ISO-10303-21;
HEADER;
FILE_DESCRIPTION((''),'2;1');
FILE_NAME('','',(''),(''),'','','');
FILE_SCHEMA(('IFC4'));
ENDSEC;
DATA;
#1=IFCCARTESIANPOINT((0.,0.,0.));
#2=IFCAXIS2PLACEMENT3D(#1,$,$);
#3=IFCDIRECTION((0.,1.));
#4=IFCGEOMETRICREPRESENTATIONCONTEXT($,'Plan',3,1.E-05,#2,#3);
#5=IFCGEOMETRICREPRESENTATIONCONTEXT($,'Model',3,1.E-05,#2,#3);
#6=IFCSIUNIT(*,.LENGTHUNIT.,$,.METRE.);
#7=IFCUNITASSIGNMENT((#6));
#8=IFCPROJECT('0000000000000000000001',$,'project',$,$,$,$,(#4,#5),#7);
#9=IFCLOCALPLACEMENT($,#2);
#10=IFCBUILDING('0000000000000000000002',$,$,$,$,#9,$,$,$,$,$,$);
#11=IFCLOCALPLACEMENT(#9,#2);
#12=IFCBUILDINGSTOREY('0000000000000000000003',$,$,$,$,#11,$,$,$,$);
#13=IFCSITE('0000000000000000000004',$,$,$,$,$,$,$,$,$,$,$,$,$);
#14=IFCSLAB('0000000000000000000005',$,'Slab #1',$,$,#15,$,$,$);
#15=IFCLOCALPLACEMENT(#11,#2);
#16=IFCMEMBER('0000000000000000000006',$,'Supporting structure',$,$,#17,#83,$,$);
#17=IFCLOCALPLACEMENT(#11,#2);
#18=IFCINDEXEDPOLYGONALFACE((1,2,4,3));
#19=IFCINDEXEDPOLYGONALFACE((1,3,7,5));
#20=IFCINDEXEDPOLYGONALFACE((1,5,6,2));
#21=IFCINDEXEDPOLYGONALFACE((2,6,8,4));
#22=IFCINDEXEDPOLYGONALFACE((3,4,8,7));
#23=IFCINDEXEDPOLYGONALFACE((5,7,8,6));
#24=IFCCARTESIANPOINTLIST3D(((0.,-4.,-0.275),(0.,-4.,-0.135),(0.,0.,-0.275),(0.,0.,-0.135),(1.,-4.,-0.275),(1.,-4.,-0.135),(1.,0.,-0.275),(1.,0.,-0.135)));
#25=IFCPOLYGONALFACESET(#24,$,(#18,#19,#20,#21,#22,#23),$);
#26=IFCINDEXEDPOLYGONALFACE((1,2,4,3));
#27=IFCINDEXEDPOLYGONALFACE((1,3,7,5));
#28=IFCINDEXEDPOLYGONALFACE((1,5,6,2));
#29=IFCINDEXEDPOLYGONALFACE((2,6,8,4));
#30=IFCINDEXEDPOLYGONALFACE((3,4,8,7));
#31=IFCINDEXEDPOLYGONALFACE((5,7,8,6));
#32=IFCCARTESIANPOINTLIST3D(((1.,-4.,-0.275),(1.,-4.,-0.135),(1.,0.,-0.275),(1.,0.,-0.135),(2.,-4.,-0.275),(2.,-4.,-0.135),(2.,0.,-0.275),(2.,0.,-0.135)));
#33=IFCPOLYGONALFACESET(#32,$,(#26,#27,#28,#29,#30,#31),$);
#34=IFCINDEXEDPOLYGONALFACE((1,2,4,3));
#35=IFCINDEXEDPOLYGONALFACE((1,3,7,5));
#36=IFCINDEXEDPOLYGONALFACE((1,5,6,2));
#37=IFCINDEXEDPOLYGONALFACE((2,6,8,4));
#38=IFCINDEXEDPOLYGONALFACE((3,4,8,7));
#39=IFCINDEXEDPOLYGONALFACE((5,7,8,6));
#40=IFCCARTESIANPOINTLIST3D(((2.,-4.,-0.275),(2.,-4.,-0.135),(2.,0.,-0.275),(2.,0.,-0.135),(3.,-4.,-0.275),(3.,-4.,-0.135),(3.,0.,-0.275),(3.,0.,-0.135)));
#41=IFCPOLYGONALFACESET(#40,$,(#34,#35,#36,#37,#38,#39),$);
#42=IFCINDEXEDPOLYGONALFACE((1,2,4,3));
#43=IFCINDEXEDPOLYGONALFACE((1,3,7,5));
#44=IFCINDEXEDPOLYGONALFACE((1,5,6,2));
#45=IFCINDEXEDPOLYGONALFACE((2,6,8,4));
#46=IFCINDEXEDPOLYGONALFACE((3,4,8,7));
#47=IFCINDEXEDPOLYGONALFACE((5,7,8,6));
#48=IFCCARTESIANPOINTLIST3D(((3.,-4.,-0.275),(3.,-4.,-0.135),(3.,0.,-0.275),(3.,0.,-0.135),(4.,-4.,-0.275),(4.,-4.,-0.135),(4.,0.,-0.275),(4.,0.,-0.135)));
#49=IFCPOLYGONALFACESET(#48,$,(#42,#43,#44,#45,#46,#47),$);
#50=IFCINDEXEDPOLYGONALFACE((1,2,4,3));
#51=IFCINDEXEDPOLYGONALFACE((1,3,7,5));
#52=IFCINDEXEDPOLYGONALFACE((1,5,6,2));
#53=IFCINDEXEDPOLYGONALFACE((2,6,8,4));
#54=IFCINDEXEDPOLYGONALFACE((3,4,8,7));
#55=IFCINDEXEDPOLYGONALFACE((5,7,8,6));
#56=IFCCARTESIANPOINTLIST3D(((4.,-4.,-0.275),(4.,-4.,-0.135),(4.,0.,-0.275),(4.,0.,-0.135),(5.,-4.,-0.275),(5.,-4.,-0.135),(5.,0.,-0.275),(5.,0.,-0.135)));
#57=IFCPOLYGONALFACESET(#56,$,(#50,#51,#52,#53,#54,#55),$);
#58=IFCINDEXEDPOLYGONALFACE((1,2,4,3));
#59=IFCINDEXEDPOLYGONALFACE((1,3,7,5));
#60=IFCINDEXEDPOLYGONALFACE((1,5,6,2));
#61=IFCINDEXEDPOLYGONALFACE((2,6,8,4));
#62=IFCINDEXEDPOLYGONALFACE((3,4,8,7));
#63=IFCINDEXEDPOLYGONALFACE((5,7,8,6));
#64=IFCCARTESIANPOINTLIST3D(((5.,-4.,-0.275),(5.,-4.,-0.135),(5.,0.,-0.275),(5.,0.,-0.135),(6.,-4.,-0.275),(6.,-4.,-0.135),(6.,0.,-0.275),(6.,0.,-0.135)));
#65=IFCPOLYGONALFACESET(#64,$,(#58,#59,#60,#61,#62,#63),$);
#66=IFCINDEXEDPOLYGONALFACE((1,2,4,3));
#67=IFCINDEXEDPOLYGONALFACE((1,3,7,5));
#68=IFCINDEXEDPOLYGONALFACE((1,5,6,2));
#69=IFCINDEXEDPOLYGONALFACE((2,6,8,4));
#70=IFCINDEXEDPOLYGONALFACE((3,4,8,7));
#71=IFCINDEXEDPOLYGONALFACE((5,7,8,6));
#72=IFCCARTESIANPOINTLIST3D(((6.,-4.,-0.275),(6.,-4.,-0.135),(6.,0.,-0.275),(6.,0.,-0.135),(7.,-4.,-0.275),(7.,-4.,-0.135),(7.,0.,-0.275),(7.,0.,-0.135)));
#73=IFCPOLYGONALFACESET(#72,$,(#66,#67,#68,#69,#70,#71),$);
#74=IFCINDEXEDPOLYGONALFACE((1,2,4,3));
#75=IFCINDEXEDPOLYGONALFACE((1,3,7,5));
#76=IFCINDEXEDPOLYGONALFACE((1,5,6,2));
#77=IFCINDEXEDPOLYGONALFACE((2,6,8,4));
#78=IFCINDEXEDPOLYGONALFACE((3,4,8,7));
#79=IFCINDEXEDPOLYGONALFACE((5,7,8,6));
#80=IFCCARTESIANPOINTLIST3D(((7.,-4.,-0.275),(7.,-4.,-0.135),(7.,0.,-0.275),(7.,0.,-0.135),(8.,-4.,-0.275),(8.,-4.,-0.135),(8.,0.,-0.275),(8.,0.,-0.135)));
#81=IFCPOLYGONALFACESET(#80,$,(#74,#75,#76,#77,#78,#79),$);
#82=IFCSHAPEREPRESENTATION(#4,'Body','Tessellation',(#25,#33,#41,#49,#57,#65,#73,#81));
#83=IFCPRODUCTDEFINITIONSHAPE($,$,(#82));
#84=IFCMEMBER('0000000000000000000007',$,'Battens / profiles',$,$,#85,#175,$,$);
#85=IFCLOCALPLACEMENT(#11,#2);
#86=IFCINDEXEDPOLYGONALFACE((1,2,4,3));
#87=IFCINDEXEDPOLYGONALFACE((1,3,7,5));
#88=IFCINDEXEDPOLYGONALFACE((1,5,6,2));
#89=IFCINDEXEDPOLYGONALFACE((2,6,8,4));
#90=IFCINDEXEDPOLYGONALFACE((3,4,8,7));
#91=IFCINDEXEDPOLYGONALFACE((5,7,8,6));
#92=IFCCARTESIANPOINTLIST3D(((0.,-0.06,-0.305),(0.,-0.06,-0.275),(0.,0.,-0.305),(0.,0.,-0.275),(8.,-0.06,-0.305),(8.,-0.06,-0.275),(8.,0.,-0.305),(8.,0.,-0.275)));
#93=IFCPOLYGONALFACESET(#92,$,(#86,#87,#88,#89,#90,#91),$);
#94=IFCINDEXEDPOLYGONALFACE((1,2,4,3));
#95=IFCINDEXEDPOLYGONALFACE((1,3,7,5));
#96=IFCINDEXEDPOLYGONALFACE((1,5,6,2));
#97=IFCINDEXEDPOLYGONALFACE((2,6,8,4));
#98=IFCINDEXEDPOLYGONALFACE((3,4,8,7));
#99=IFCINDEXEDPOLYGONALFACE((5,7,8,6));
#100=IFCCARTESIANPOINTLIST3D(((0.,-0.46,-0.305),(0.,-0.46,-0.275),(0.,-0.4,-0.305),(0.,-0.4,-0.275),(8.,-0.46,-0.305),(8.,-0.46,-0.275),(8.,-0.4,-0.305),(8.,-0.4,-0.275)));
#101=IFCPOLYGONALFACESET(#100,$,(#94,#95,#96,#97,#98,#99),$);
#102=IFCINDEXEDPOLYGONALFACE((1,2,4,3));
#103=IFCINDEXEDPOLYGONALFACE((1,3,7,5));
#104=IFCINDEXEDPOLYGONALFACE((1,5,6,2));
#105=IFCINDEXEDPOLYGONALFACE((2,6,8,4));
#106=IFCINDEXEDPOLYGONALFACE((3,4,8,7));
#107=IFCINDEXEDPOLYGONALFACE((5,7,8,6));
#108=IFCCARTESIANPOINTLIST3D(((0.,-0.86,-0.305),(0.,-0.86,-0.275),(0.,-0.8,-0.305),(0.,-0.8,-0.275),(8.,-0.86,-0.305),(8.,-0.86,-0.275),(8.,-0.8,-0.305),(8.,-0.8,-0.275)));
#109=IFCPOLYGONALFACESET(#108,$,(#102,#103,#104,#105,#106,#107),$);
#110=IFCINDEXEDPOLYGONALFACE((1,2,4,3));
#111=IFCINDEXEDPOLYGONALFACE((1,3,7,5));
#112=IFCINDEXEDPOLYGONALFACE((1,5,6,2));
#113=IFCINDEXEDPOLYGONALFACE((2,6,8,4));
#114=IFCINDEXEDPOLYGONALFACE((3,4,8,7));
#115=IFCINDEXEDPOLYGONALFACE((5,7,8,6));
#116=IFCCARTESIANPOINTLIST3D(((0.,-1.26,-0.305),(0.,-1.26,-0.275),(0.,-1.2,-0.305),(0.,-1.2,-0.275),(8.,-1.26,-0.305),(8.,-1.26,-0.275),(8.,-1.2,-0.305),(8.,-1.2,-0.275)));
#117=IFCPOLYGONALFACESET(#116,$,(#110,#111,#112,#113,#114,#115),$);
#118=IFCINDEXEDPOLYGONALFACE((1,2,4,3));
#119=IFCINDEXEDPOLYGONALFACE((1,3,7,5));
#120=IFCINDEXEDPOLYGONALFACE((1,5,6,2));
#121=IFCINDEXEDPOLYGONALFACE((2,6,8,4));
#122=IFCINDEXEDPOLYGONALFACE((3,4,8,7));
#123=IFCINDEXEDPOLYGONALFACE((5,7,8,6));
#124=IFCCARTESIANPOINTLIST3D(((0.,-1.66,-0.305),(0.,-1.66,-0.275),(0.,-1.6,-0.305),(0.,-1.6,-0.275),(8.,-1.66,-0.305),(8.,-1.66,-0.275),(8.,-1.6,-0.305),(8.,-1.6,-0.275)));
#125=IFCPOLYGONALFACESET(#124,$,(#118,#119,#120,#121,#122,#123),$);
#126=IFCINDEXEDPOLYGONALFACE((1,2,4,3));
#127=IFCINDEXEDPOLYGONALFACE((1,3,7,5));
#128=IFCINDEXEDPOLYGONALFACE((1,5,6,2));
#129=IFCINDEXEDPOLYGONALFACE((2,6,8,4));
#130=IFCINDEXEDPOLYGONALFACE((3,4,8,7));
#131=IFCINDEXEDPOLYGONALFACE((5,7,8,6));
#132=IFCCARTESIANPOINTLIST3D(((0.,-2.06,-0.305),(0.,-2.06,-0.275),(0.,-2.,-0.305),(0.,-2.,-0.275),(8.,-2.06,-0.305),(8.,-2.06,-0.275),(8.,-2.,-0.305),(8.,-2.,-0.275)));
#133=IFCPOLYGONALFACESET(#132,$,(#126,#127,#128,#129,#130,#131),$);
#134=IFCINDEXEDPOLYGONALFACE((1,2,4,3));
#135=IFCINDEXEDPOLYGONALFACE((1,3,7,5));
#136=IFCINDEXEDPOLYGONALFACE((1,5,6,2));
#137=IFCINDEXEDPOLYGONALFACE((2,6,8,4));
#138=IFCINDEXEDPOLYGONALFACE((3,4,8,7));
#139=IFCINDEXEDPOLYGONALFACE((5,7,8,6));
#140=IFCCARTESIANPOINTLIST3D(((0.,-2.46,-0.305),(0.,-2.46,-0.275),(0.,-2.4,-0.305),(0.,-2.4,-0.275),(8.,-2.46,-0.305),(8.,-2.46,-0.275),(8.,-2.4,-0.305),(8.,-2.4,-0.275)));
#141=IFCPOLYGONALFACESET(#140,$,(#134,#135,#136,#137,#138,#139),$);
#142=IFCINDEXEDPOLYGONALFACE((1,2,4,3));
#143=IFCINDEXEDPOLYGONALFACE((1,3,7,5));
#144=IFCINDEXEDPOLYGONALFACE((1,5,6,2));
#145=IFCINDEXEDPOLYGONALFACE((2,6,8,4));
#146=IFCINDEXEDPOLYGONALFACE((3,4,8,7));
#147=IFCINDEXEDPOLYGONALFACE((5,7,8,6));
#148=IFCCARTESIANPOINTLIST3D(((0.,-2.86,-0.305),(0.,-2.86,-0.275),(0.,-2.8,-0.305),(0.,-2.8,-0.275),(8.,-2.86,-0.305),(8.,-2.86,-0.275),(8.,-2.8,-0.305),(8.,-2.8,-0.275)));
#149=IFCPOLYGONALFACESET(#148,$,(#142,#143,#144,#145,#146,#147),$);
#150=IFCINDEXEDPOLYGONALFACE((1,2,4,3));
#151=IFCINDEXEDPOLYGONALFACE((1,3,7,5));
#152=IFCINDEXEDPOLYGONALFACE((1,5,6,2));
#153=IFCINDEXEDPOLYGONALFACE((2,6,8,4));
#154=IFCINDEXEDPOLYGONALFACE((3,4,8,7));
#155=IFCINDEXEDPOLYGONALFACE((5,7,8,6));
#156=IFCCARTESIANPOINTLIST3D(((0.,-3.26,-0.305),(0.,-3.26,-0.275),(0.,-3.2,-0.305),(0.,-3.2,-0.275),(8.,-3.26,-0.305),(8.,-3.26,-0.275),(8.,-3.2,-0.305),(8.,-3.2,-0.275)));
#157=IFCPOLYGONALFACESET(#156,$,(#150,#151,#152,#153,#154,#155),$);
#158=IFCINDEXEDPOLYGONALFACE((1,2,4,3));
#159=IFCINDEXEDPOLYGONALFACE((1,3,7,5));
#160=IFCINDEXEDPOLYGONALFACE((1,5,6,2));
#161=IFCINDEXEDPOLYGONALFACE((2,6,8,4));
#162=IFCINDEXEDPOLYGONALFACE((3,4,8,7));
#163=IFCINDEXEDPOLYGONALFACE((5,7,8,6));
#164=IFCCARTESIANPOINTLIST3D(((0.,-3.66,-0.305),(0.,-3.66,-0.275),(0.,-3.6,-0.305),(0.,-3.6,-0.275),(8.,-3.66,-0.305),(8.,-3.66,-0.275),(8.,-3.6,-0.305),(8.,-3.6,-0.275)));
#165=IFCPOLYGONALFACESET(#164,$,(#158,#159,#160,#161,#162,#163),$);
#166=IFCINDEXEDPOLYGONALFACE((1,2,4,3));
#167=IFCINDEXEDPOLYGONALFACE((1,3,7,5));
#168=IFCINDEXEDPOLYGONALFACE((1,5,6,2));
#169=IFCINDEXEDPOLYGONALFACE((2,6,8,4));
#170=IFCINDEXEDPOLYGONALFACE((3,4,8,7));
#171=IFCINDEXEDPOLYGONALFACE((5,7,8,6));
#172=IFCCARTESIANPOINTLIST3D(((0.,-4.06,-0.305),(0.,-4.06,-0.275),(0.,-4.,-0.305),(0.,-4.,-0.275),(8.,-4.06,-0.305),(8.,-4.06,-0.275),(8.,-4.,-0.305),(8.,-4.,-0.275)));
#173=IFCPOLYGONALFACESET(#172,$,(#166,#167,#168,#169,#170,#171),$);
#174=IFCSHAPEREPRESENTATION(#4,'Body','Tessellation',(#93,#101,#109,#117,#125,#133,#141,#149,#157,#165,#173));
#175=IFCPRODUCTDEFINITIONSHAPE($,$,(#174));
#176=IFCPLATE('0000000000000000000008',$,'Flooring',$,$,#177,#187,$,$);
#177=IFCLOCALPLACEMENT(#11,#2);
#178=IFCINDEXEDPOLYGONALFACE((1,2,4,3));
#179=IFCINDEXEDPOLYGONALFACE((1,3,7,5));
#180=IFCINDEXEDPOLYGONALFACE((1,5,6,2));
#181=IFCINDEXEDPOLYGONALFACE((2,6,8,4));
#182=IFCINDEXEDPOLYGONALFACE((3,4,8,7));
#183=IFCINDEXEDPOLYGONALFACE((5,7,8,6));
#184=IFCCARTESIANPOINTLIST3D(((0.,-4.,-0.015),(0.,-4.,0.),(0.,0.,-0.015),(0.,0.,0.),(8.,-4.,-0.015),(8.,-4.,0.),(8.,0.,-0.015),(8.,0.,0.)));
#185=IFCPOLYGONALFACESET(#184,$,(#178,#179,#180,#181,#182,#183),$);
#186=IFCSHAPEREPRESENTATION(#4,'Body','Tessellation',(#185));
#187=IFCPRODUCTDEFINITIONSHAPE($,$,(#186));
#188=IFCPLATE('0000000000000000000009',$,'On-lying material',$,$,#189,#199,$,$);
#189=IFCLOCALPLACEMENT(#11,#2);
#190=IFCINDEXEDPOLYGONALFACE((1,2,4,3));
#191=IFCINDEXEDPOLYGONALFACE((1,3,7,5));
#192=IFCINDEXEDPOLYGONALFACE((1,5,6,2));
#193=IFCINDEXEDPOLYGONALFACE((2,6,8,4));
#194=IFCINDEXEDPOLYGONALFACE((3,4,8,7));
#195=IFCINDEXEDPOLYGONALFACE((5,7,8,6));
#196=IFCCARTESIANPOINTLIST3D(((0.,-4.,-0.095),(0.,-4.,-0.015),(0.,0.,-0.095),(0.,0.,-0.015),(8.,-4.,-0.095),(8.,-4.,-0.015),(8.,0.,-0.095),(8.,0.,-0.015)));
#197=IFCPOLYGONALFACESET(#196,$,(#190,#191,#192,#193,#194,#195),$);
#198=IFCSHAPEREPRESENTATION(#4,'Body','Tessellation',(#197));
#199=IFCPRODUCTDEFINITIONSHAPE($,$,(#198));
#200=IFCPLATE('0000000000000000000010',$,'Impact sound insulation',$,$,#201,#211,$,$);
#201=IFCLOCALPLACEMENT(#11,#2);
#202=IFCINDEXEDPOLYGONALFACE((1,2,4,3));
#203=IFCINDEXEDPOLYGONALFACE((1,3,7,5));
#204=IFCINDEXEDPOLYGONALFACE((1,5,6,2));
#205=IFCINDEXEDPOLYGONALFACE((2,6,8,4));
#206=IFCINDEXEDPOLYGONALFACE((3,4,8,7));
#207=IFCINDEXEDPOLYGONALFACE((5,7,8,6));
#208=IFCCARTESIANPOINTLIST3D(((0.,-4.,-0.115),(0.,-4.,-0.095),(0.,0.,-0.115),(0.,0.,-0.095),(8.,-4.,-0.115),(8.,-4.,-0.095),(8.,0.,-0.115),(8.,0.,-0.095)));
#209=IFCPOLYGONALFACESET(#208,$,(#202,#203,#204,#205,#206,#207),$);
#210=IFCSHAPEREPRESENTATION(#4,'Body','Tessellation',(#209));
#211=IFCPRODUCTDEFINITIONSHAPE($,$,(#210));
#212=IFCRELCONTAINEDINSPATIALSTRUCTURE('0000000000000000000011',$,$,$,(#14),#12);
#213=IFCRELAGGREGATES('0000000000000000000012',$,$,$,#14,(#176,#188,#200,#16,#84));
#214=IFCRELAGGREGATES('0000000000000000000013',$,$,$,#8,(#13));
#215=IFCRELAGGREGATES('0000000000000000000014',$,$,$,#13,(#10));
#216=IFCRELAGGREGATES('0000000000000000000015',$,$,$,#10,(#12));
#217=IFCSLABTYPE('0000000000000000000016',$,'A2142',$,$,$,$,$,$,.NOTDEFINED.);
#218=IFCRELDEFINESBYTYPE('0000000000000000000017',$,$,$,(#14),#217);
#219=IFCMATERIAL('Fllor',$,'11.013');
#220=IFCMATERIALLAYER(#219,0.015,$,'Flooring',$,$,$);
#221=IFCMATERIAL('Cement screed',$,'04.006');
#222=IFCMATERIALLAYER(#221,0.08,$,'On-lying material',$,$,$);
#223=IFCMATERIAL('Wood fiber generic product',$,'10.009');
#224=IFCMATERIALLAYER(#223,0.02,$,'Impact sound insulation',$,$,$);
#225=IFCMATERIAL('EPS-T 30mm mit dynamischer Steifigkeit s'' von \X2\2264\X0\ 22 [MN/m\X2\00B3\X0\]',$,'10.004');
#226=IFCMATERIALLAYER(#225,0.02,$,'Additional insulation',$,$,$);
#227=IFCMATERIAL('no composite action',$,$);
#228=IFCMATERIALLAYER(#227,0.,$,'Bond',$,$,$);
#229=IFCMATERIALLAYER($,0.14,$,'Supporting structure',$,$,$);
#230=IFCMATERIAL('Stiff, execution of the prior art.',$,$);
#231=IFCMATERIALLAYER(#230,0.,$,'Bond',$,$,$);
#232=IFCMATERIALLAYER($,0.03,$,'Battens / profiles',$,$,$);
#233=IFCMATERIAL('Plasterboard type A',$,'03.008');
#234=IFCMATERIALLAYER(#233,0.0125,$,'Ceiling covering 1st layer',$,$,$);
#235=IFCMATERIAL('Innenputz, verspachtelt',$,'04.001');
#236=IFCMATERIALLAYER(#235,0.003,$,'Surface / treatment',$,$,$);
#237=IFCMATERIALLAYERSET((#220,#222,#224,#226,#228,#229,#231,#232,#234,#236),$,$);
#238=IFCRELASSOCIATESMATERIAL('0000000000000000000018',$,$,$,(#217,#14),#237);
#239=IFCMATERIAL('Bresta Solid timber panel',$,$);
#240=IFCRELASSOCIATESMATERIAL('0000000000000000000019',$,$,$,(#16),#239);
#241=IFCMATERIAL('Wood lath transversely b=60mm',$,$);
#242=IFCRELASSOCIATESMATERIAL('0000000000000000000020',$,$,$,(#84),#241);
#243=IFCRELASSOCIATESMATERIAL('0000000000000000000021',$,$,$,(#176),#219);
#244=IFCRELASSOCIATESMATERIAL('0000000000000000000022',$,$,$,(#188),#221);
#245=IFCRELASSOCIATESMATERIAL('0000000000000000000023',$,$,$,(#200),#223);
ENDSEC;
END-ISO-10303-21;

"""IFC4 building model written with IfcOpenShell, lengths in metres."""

from ifc_helpers import new_model, si_unit, direction, frame, frame_2d, origin, origin_with_axes, place, context, project, spatial, rectangle, extrude, material, layer, layer_set, type_object, element, aggregate, save


model = new_model("IFC4")

# Units and contexts
plan_context = context("Plan", 3, precision=1e-05, world=origin(), true_north=direction((0.0, 1.0)))
model_context = context("Model", 3, precision=1e-05, world=origin(), true_north=direction((0.0, 1.0)))
ifc_project = project(units=[si_unit("LENGTHUNIT", "METRE")], contexts=[plan_context, model_context])

# Site, building, storey
site = spatial("IfcSite", under=ifc_project)
building_placement = place(None, origin())
building = spatial("IfcBuilding", under=site, at=building_placement)
storey_placement = place(building_placement, origin())
storey = spatial("IfcBuildingStorey", under=building, at=storey_placement)

# Slab, members, plates
ifc_material_1 = material(Name="Fllor", Category="11.013")
ifc_layer_1 = layer(ifc_material_1, 0.015, Name="Flooring")
ifc_material_2 = material(Name="Cement screed", Category="04.006")
ifc_layer_2 = layer(ifc_material_2, 0.08, Name="On-lying material")
ifc_material_3 = material(Name="Wood fiber generic product", Category="10.009")
ifc_layer_3 = layer(ifc_material_3, 0.02, Name="Impact sound insulation")
ifc_material_4 = material(Name="EPS-T 30mm mit dynamischer Steifigkeit s' von ≤ 22 [MN/m³]", Category="10.004")
ifc_layer_4 = layer(ifc_material_4, 0.02, Name="Additional insulation")
ifc_material_5 = material(Name="no composite action")
ifc_layer_5 = layer(ifc_material_5, 0.0, Name="Bond")
ifc_layer_6 = layer(None, 0.14, Name="Supporting structure")
ifc_material_6 = material(Name="Stiff, execution of the prior art.")
ifc_layer_7 = layer(ifc_material_6, 0.0, Name="Bond")
ifc_layer_8 = layer(None, 0.03, Name="Battens / profiles")
ifc_material_7 = material(Name="Plasterboard type A", Category="03.008")
ifc_layer_9 = layer(ifc_material_7, 0.0125, Name="Ceiling covering 1st layer")
ifc_material_8 = material(Name="Innenputz, verspachtelt", Category="04.001")
ifc_layer_10 = layer(ifc_material_8, 0.003, Name="Surface / treatment")
ifc_layer_set = layer_set([ifc_layer_1, ifc_layer_2, ifc_layer_3, ifc_layer_4, ifc_layer_5, ifc_layer_6, ifc_layer_7, ifc_layer_8, ifc_layer_9, ifc_layer_10])
slab_type = type_object("IfcSlabType", Name="A2142", PredefinedType="NOTDEFINED", material=ifc_layer_set)
slab_placement = place(None, frame((0.0, 0.0, 0.0), z_axis=(0.0, 0.0, -1.0), x_axis=(1.0, 0.0, 0.0)))
slab = element("IfcSlab", 1, at=slab_placement, inside=storey, type_object=slab_type, material=ifc_layer_set, Name="Slab #1")
ifc_material_9 = material(Name="Bresta Solid timber panel")
member_1_placement = place(slab_placement, origin())
member_1 = element("IfcMember", 2, at=member_1_placement, material=ifc_material_9, Name="Supporting structure", context=plan_context, shape_type="SweptSolid", body=[
    extrude(rectangle(XDim=1.0, YDim=0.14, at=frame_2d((0.5, 0.07), x_axis=(1.0, 0.0))), frame((0.0, 4.0, 0.135), z_axis=(0.0, -1.0, 0.0), x_axis=(1.0, 0.0, 0.0)), (0.0, 0.0, 1.0), 4.0),
    extrude(rectangle(XDim=1.0, YDim=0.14, at=frame_2d((0.5, 0.07), x_axis=(1.0, 0.0))), frame((1.0, 4.0, 0.135), z_axis=(0.0, -1.0, 0.0), x_axis=(1.0, 0.0, 0.0)), (0.0, 0.0, 1.0), 4.0),
    extrude(rectangle(XDim=1.0, YDim=0.14, at=frame_2d((0.5, 0.07), x_axis=(1.0, 0.0))), frame((2.0, 4.0, 0.135), z_axis=(0.0, -1.0, 0.0), x_axis=(1.0, 0.0, 0.0)), (0.0, 0.0, 1.0), 4.0),
    extrude(rectangle(XDim=1.0, YDim=0.14, at=frame_2d((0.5, 0.07), x_axis=(1.0, 0.0))), frame((3.0, 4.0, 0.135), z_axis=(0.0, -1.0, 0.0), x_axis=(1.0, 0.0, 0.0)), (0.0, 0.0, 1.0), 4.0),
    extrude(rectangle(XDim=1.0, YDim=0.14, at=frame_2d((0.5, 0.07), x_axis=(1.0, 0.0))), frame((4.0, 4.0, 0.135), z_axis=(0.0, -1.0, 0.0), x_axis=(1.0, 0.0, 0.0)), (0.0, 0.0, 1.0), 4.0),
    extrude(rectangle(XDim=1.0, YDim=0.14, at=frame_2d((0.5, 0.07), x_axis=(1.0, 0.0))), frame((5.0, 4.0, 0.135), z_axis=(0.0, -1.0, 0.0), x_axis=(1.0, 0.0, 0.0)), (0.0, 0.0, 1.0), 4.0),
    extrude(rectangle(XDim=1.0, YDim=0.14, at=frame_2d((0.5, 0.07), x_axis=(1.0, 0.0))), frame((6.0, 4.0, 0.135), z_axis=(0.0, -1.0, 0.0), x_axis=(1.0, 0.0, 0.0)), (0.0, 0.0, 1.0), 4.0),
    extrude(rectangle(XDim=1.0, YDim=0.14, at=frame_2d((0.5, 0.07), x_axis=(1.0, 0.0))), frame((7.0, 4.0, 0.135), z_axis=(0.0, -1.0, 0.0), x_axis=(1.0, 0.0, 0.0)), (0.0, 0.0, 1.0), 4.0),
])
ifc_material_10 = material(Name="Wood lath transversely b=60mm")
member_2_placement = place(slab_placement, origin())
member_2 = element("IfcMember", 3, at=member_2_placement, material=ifc_material_10, Name="Battens / profiles", context=plan_context, shape_type="SweptSolid", body=[
    extrude(rectangle(XDim=0.06, YDim=0.03, at=frame_2d((0.03, 0.015), x_axis=(1.0, 0.0))), frame((0.0, 0.0, 0.275), z_axis=(1.0, 0.0, 0.0), x_axis=(0.0, 1.0, 0.0)), (0.0, 0.0, 1.0), 8.0),
    extrude(rectangle(XDim=0.06, YDim=0.03, at=frame_2d((0.03, 0.015), x_axis=(1.0, 0.0))), frame((0.0, 0.4, 0.275), z_axis=(1.0, 0.0, 0.0), x_axis=(0.0, 1.0, 0.0)), (0.0, 0.0, 1.0), 8.0),
    extrude(rectangle(XDim=0.06, YDim=0.03, at=frame_2d((0.03, 0.015), x_axis=(1.0, 0.0))), frame((0.0, 0.8, 0.275), z_axis=(1.0, 0.0, 0.0), x_axis=(0.0, 1.0, 0.0)), (0.0, 0.0, 1.0), 8.0),
    extrude(rectangle(XDim=0.06, YDim=0.03, at=frame_2d((0.03, 0.015), x_axis=(1.0, 0.0))), frame((0.0, 1.2, 0.275), z_axis=(1.0, 0.0, 0.0), x_axis=(0.0, 1.0, 0.0)), (0.0, 0.0, 1.0), 8.0),
    extrude(rectangle(XDim=0.06, YDim=0.03, at=frame_2d((0.03, 0.015), x_axis=(1.0, 0.0))), frame((0.0, 1.6, 0.275), z_axis=(1.0, 0.0, 0.0), x_axis=(0.0, 1.0, 0.0)), (0.0, 0.0, 1.0), 8.0),
    extrude(rectangle(XDim=0.06, YDim=0.03, at=frame_2d((0.03, 0.015), x_axis=(1.0, 0.0))), frame((0.0, 2.0, 0.275), z_axis=(1.0, 0.0, 0.0), x_axis=(0.0, 1.0, 0.0)), (0.0, 0.0, 1.0), 8.0),
    extrude(rectangle(XDim=0.06, YDim=0.03, at=frame_2d((0.03, 0.015), x_axis=(1.0, 0.0))), frame((0.0, 2.4, 0.275), z_axis=(1.0, 0.0, 0.0), x_axis=(0.0, 1.0, 0.0)), (0.0, 0.0, 1.0), 8.0),
    extrude(rectangle(XDim=0.06, YDim=0.03, at=frame_2d((0.03, 0.015), x_axis=(1.0, 0.0))), frame((0.0, 2.8, 0.275), z_axis=(1.0, 0.0, 0.0), x_axis=(0.0, 1.0, 0.0)), (0.0, 0.0, 1.0), 8.0),
    extrude(rectangle(XDim=0.06, YDim=0.03, at=frame_2d((0.03, 0.015), x_axis=(1.0, 0.0))), frame((0.0, 3.2, 0.275), z_axis=(1.0, 0.0, 0.0), x_axis=(0.0, 1.0, 0.0)), (0.0, 0.0, 1.0), 8.0),
    extrude(rectangle(XDim=0.06, YDim=0.03, at=frame_2d((0.03, 0.015), x_axis=(1.0, 0.0))), frame((0.0, 3.6, 0.275), z_axis=(1.0, 0.0, 0.0), x_axis=(0.0, 1.0, 0.0)), (0.0, 0.0, 1.0), 8.0),
    extrude(rectangle(XDim=0.06, YDim=0.03, at=frame_2d((0.03, 0.015), x_axis=(1.0, 0.0))), frame((0.0, 4.0, 0.275), z_axis=(1.0, 0.0, 0.0), x_axis=(0.0, 1.0, 0.0)), (0.0, 0.0, 1.0), 8.0),
])
plate_1_placement = place(slab_placement, origin())
plate_1 = element("IfcPlate", 4, at=plate_1_placement, material=ifc_material_1, Name="Flooring", context=plan_context, shape_type="SweptSolid", body=[
    extrude(rectangle(XDim=8.0, YDim=4.0, at=frame_2d((4.0, 2.0), x_axis=(1.0, 0.0))), origin_with_axes(), (0.0, 0.0, 1.0), 0.015),
])
plate_2_placement = place(slab_placement, origin())
plate_2 = element("IfcPlate", 5, at=plate_2_placement, material=ifc_material_2, Name="On-lying material", context=plan_context, shape_type="SweptSolid", body=[
    extrude(rectangle(XDim=8.0, YDim=4.0, at=frame_2d((4.0, 2.0), x_axis=(1.0, 0.0))), frame((0.0, 0.0, 0.015), z_axis=(0.0, 0.0, 1.0), x_axis=(1.0, 0.0, 0.0)), (0.0, 0.0, 1.0), 0.08),
])
plate_3_placement = place(slab_placement, origin())
plate_3 = element("IfcPlate", 6, at=plate_3_placement, material=ifc_material_3, Name="Impact sound insulation", context=plan_context, shape_type="SweptSolid", body=[
    extrude(rectangle(XDim=8.0, YDim=4.0, at=frame_2d((4.0, 2.0), x_axis=(1.0, 0.0))), frame((0.0, 0.0, 0.095), z_axis=(0.0, 0.0, 1.0), x_axis=(1.0, 0.0, 0.0)), (0.0, 0.0, 1.0), 0.02),
])
aggregate(slab, [plate_1, plate_2, plate_3, member_1, member_2])

save(model, "model.ifc")
